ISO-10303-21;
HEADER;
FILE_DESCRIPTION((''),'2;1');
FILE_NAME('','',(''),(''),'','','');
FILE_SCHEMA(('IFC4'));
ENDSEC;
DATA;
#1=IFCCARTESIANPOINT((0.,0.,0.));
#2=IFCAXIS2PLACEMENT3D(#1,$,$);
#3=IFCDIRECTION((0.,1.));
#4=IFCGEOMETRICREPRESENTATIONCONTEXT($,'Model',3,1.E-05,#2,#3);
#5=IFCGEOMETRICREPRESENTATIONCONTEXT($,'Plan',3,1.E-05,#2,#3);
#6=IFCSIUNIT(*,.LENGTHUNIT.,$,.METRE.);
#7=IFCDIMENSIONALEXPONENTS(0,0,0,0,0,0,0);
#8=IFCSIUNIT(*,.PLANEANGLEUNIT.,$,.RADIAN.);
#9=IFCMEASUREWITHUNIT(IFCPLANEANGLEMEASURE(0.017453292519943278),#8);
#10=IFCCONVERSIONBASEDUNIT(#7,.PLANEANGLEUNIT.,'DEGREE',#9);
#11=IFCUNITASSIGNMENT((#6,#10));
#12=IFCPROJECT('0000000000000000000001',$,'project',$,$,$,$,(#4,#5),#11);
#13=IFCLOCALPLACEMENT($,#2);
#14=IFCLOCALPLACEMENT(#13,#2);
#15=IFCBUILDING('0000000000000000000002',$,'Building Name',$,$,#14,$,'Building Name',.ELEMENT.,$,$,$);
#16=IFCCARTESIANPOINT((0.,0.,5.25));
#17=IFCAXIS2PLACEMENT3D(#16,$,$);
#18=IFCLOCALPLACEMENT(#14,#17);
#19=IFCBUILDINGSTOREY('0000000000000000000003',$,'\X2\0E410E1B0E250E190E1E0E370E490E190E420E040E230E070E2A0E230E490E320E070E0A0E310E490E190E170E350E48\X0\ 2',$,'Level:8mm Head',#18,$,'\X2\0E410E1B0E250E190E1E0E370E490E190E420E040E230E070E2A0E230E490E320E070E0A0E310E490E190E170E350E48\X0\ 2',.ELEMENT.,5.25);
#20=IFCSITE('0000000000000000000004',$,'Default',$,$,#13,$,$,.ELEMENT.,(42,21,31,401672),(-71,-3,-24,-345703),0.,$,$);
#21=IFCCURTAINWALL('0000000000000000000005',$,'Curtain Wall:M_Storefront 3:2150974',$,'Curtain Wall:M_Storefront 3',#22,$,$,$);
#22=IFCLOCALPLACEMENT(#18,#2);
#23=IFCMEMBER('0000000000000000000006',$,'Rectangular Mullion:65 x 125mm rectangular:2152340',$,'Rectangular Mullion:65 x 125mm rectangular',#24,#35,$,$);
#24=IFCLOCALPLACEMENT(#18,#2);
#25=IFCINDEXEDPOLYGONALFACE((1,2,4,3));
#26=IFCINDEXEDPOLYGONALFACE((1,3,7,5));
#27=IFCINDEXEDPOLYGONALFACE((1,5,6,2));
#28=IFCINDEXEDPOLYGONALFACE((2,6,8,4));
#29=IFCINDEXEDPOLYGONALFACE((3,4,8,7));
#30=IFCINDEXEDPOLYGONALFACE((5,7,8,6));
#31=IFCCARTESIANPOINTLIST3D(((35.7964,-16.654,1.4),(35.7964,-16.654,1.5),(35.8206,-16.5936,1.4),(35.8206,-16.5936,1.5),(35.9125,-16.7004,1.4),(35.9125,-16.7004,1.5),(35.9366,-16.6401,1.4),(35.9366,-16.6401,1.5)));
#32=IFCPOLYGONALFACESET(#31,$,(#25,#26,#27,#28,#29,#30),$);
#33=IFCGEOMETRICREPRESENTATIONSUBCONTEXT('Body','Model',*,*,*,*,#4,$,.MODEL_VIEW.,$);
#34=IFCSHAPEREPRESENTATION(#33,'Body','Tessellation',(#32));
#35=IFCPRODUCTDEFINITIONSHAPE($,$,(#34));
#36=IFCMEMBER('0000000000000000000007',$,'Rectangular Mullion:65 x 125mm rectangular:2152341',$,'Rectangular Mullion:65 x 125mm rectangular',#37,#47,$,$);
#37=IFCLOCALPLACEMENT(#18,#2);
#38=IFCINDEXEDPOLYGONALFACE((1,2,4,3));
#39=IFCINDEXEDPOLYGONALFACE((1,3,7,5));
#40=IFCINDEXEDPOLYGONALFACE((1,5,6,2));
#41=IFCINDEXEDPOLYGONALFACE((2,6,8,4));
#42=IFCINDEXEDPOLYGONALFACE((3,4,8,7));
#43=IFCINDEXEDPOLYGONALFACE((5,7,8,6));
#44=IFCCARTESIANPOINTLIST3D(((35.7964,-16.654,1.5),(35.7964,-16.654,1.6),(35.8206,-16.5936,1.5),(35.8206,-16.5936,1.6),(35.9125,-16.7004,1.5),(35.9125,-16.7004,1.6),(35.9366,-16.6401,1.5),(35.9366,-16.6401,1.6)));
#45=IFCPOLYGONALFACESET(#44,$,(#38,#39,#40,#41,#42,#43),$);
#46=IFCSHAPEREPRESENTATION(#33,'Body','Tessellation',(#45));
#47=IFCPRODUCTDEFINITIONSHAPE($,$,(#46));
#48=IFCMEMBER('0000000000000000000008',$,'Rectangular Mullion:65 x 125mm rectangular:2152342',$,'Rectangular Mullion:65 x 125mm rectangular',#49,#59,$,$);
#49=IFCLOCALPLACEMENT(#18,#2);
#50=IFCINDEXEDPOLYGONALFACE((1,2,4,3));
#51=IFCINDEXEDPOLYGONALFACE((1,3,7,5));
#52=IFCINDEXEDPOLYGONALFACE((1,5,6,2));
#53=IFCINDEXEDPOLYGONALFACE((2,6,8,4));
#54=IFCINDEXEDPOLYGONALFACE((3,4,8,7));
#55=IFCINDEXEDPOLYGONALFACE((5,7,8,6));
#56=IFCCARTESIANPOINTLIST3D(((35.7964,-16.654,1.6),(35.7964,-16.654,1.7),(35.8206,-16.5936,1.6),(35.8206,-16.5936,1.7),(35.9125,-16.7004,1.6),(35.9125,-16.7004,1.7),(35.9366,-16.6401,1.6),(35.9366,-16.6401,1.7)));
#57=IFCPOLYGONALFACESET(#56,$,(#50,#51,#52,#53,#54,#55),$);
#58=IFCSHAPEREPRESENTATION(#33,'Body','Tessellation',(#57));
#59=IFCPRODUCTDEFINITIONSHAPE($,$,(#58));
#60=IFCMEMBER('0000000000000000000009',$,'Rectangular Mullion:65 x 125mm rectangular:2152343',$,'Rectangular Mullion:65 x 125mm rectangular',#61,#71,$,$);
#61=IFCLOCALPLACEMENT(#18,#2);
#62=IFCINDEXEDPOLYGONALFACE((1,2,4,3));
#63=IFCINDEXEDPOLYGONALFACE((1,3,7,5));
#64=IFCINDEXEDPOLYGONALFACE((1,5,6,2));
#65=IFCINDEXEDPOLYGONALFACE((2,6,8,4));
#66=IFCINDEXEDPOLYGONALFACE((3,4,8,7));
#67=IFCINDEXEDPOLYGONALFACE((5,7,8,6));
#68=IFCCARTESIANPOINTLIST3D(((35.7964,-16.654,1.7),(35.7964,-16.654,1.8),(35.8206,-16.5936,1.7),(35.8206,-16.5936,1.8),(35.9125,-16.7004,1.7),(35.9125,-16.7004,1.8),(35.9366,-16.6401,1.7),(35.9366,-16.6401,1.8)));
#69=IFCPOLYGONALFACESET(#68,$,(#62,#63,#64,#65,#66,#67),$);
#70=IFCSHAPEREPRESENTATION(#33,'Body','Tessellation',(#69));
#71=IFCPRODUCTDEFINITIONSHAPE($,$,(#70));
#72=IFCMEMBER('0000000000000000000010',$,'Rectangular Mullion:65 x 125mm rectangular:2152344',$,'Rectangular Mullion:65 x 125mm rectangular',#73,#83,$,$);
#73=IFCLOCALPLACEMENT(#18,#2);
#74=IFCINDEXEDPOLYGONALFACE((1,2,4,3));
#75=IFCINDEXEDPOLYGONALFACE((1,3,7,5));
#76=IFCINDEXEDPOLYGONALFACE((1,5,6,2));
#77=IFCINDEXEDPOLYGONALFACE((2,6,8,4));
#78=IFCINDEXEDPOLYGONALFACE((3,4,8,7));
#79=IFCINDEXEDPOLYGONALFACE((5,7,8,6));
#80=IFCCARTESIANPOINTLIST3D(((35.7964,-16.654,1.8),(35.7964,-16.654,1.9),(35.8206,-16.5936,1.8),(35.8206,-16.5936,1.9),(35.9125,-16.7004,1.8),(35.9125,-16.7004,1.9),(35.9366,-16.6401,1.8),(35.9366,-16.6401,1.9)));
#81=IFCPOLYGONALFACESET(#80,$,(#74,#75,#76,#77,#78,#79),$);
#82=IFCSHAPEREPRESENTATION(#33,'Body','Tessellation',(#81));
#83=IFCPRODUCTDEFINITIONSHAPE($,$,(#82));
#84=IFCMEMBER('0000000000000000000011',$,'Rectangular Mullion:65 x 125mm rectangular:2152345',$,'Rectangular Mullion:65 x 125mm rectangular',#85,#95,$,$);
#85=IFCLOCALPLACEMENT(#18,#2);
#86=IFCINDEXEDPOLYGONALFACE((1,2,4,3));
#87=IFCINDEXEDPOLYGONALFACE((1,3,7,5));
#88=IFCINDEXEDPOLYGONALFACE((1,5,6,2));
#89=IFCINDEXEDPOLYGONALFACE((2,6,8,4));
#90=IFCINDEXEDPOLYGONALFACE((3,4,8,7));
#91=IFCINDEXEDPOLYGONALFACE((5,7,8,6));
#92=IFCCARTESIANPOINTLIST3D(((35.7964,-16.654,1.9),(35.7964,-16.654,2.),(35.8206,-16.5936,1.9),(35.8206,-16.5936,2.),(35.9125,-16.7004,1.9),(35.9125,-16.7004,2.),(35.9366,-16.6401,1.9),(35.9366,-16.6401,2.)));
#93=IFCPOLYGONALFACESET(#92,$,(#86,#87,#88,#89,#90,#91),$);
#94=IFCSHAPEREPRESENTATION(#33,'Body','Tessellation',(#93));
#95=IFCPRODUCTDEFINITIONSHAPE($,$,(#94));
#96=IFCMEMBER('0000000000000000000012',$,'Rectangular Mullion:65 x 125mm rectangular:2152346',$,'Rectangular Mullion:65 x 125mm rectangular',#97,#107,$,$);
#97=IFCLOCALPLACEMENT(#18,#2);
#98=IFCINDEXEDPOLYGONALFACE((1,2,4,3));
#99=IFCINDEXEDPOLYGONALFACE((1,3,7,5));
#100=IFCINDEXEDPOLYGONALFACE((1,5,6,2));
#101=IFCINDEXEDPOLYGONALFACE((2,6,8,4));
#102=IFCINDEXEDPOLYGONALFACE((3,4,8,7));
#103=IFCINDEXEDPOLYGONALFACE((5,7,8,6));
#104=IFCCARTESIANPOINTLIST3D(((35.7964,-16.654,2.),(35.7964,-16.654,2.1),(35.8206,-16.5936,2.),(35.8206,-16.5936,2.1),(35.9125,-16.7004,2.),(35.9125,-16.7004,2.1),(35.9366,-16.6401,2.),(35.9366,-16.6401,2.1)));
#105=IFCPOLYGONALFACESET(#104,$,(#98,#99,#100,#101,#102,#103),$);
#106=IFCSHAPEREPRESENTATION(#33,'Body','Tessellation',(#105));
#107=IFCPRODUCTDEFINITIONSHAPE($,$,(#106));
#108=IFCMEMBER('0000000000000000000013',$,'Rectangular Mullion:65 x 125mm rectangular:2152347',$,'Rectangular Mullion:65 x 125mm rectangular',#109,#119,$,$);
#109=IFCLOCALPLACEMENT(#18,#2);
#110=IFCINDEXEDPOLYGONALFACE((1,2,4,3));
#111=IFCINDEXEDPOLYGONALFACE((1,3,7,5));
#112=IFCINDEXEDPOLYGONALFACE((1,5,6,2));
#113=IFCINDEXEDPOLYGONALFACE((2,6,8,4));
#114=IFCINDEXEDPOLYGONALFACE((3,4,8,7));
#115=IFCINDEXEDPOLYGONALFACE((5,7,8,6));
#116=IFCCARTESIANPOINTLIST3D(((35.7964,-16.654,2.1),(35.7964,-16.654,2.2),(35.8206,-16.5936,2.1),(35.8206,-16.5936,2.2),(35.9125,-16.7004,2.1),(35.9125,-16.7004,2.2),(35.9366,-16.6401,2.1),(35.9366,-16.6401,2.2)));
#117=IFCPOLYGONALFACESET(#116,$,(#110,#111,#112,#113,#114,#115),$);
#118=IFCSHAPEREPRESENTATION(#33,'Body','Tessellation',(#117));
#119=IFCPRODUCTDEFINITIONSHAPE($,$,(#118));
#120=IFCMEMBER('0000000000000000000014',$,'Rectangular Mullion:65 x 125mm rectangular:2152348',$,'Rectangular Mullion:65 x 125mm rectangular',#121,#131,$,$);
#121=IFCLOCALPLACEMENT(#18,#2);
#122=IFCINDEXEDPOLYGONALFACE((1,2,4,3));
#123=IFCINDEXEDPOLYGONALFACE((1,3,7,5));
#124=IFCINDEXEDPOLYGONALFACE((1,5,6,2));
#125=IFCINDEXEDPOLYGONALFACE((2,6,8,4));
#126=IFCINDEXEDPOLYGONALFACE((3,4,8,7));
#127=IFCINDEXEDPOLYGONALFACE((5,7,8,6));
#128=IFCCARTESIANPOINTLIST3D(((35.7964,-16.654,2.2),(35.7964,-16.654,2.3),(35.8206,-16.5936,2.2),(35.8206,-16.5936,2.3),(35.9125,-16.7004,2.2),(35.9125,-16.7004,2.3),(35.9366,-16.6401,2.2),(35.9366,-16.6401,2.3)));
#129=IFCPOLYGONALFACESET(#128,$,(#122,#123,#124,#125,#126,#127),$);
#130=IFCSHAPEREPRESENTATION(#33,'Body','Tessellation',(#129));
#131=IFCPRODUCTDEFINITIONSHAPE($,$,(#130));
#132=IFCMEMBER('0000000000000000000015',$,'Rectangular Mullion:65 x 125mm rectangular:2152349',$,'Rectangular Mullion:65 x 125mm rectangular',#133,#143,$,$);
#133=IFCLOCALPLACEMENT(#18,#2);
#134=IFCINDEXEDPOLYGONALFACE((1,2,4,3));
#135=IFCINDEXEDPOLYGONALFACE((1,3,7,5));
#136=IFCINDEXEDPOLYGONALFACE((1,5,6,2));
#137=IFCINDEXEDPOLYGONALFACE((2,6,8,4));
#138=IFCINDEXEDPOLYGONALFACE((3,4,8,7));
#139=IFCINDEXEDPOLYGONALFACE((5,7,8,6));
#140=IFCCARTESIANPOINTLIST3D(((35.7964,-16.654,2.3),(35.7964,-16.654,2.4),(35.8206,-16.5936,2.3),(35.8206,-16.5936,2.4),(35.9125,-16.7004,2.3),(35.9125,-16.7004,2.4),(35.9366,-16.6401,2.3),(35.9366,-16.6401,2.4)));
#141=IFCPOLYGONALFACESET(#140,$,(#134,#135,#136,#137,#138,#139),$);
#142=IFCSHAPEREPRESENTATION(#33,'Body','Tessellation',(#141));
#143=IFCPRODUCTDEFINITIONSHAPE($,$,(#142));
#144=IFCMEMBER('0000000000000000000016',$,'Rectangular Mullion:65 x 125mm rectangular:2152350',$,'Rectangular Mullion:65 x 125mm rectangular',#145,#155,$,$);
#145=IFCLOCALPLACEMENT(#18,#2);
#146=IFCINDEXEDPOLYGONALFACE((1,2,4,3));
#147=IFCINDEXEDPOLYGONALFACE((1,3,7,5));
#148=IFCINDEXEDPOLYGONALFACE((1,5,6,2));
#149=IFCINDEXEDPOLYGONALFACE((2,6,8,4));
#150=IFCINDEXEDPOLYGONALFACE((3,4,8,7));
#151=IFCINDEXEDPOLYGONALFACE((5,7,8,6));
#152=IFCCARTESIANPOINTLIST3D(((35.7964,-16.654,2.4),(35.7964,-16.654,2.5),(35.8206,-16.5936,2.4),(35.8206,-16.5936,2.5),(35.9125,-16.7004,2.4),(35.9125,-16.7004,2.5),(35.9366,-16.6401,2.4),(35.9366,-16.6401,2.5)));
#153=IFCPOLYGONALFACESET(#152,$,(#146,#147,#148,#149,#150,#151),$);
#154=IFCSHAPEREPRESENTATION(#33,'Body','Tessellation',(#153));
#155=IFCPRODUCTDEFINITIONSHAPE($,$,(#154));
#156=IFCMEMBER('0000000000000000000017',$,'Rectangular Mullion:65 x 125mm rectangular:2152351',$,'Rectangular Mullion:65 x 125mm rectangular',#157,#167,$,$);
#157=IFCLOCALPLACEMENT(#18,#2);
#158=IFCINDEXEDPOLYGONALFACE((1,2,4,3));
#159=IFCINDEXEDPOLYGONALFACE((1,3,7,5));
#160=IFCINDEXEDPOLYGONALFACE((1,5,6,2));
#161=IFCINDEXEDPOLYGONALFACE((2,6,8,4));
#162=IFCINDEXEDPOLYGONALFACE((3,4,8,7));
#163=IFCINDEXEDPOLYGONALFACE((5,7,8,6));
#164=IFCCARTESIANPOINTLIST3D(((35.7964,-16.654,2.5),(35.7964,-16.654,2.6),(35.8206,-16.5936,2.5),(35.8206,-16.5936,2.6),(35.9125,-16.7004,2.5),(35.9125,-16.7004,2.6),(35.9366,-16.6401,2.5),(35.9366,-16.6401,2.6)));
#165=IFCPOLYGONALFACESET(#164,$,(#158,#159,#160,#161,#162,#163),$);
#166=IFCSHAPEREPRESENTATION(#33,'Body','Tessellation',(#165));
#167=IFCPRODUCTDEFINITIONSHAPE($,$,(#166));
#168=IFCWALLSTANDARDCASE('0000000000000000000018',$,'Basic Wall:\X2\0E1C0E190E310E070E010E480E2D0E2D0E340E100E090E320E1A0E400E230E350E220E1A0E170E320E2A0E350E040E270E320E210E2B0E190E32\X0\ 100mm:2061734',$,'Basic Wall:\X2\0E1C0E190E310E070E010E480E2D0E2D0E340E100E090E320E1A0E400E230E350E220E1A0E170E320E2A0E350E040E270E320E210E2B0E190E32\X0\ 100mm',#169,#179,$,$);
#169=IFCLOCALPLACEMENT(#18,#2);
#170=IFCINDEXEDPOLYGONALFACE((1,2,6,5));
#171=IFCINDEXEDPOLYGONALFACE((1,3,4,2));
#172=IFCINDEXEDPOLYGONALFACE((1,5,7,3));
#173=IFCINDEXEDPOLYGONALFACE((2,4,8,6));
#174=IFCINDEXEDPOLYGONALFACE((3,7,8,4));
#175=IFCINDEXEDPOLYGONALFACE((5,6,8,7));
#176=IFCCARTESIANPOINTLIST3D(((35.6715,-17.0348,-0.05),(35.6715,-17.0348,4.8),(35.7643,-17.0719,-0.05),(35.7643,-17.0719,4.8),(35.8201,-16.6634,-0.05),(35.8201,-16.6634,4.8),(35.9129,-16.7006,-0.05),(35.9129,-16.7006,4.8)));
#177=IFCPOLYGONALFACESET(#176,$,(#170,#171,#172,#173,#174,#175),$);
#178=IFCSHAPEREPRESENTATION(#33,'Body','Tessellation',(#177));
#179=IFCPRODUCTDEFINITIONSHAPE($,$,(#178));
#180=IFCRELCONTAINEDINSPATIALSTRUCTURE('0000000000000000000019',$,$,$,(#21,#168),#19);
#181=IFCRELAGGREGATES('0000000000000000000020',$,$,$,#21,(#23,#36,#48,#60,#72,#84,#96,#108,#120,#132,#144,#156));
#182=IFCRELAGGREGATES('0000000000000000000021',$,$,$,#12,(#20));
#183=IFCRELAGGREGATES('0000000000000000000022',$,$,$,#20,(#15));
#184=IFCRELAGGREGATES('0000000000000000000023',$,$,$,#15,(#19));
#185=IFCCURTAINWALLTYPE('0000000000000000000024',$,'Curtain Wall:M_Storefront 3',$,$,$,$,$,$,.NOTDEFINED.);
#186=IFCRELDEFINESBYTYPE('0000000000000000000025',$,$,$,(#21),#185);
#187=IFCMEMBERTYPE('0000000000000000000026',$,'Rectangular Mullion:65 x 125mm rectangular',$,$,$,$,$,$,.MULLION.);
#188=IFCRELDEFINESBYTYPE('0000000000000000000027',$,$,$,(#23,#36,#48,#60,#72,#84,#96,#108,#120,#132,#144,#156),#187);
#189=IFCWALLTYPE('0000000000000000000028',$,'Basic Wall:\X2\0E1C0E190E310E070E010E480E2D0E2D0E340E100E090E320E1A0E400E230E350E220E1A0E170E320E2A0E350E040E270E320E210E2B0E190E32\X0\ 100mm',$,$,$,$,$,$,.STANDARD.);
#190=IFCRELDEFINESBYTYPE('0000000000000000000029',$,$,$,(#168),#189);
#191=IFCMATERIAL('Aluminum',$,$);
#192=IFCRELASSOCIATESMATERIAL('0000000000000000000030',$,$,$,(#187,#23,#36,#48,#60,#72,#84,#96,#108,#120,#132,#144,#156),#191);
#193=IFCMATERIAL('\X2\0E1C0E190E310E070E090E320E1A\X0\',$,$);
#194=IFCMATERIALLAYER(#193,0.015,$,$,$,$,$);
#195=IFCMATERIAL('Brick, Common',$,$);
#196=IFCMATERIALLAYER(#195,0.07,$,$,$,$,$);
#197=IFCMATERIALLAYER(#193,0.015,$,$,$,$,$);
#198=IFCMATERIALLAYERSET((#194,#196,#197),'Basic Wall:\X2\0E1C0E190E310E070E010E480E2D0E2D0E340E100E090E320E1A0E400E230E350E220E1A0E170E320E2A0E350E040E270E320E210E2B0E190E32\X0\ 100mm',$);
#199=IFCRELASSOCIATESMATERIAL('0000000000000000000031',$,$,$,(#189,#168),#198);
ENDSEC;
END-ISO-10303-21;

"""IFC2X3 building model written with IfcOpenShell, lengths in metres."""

from ifc_helpers import new_model, entity, si_unit, converted_unit, direction, frame, frame_2d, origin, origin_2d_with_axis, place, context, subcontext, project, spatial, rectangle, extrude, source, transform, mapped, material, layer, layer_set, layer_usage, type_object, type_shapes, element, aggregate, save


model = new_model("IFC2X3")

# Units and contexts
model_context = context("Model", 3, precision=1e-05, world=origin(), true_north=direction((0.0, 1.0)))
plan_context = context("Plan", 3, precision=1e-05, world=origin(), true_north=direction((0.0, 1.0)))
body_context = subcontext(model_context, "Body", "Model", "MODEL_VIEW")
ifc_project = project(units=[si_unit("LENGTHUNIT", "METRE"), converted_unit("PLANEANGLEUNIT", "DEGREE", entity("IfcPlaneAngleMeasure", 0.017453292519943278), si_unit("PLANEANGLEUNIT", "RADIAN"), dimensions=[0, 0, 0, 0, 0, 0, 0])], contexts=[model_context, plan_context])

# Site, building, storey
site_placement = place(None, origin())
site = spatial("IfcSite", under=ifc_project, at=site_placement, Name="Default", CompositionType="ELEMENT", RefLatitude=(42, 21, 31, 401672), RefLongitude=(-71, -3, -24, -345703), RefElevation=0.0)
building_placement = place(site_placement, origin())
building = spatial("IfcBuilding", under=site, at=building_placement, Name="Building Name", LongName="Building Name", CompositionType="ELEMENT")
storey_placement = place(building_placement, frame((0.0, 0.0, 5.25)))
storey = spatial("IfcBuildingStorey", under=building, at=storey_placement, Name="แปลนพื้นโครงสร้างชั้นที่ 2", ObjectType="Level:8mm Head", LongName="แปลนพื้นโครงสร้างชั้นที่ 2", CompositionType="ELEMENT", Elevation=5.25)

# Curtain wall, members
curtain_wall_type = type_object("IfcCurtainWallType", Name="Curtain Wall:M_Storefront 3", PredefinedType="NOTDEFINED")
ifc_material_1 = material(Name="Aluminum")
curtain_wall_1_placement = place(storey_placement, frame((0.0, 0.0, -5.25)))
curtain_wall_1 = element("IfcCurtainWall", 1, at=curtain_wall_1_placement, inside=storey, type_object=curtain_wall_type, Name="Curtain Wall:M_Storefront 3:2150974", ObjectType="Curtain Wall:M_Storefront 3")
member_type_1 = type_object("IfcMemberType", Name="Rectangular Mullion:65 x 125mm rectangular", PredefinedType="MULLION", material=ifc_material_1)
shared_shape_1 = source(origin(), body_context, "Body", "SweptSolid", [
    extrude(rectangle(XDim=0.065, YDim=0.125, at=origin_2d_with_axis()), frame((-0.0325, 0.0, -0.1), z_axis=(0.0, 0.0, 1.0), x_axis=(-1.0, 0.0, 0.0)), (0.0, 0.0, 1.0), 0.1),
])
type_shapes(member_type_1, [shared_shape_1])
member_1_placement = place(curtain_wall_1_placement, frame((35.8545, -16.6772, 6.75), z_axis=(0.0, 0.0, 1.0), x_axis=(-0.371573, -0.928404, 0.0)))
member_1 = element("IfcMember", 2, at=member_1_placement, type_object=member_type_1, material=ifc_material_1, Name="Rectangular Mullion:65 x 125mm rectangular:2152340", ObjectType="Rectangular Mullion:65 x 125mm rectangular", context=body_context, shape_type="MappedRepresentation", body=[
    mapped(shared_shape_1, transform((0.0, 0.0, 0.0), scale=1.0)),
])
member_2_placement = place(curtain_wall_1_placement, frame((35.8545, -16.6772, 6.85), z_axis=(0.0, 0.0, 1.0), x_axis=(-0.371573, -0.928404, 0.0)))
member_2 = element("IfcMember", 3, at=member_2_placement, type_object=member_type_1, material=ifc_material_1, Name="Rectangular Mullion:65 x 125mm rectangular:2152341", ObjectType="Rectangular Mullion:65 x 125mm rectangular", context=body_context, shape_type="MappedRepresentation", body=[
    mapped(shared_shape_1, transform((0.0, 0.0, 0.0), scale=1.0)),
])
member_3_placement = place(curtain_wall_1_placement, frame((35.8545, -16.6772, 6.95), z_axis=(0.0, 0.0, 1.0), x_axis=(-0.371573, -0.928404, 0.0)))
member_3 = element("IfcMember", 4, at=member_3_placement, type_object=member_type_1, material=ifc_material_1, Name="Rectangular Mullion:65 x 125mm rectangular:2152342", ObjectType="Rectangular Mullion:65 x 125mm rectangular", context=body_context, shape_type="MappedRepresentation", body=[
    mapped(shared_shape_1, transform((0.0, 0.0, 0.0), scale=1.0)),
])
member_4_placement = place(curtain_wall_1_placement, frame((35.8545, -16.6772, 7.05), z_axis=(0.0, 0.0, 1.0), x_axis=(-0.371573, -0.928404, 0.0)))
member_4 = element("IfcMember", 5, at=member_4_placement, type_object=member_type_1, material=ifc_material_1, Name="Rectangular Mullion:65 x 125mm rectangular:2152343", ObjectType="Rectangular Mullion:65 x 125mm rectangular", context=body_context, shape_type="MappedRepresentation", body=[
    mapped(shared_shape_1, transform((0.0, 0.0, 0.0), scale=1.0)),
])
member_5_placement = place(curtain_wall_1_placement, frame((35.8545, -16.6772, 7.15), z_axis=(0.0, 0.0, 1.0), x_axis=(-0.371573, -0.928404, 0.0)))
member_5 = element("IfcMember", 6, at=member_5_placement, type_object=member_type_1, material=ifc_material_1, Name="Rectangular Mullion:65 x 125mm rectangular:2152344", ObjectType="Rectangular Mullion:65 x 125mm rectangular", context=body_context, shape_type="MappedRepresentation", body=[
    mapped(shared_shape_1, transform((0.0, 0.0, 0.0), scale=1.0)),
])
member_6_placement = place(curtain_wall_1_placement, frame((35.8545, -16.6772, 7.25), z_axis=(0.0, 0.0, 1.0), x_axis=(-0.371573, -0.928404, 0.0)))
member_6 = element("IfcMember", 7, at=member_6_placement, type_object=member_type_1, material=ifc_material_1, Name="Rectangular Mullion:65 x 125mm rectangular:2152345", ObjectType="Rectangular Mullion:65 x 125mm rectangular", context=body_context, shape_type="MappedRepresentation", body=[
    mapped(shared_shape_1, transform((0.0, 0.0, 0.0), scale=1.0)),
])
member_7_placement = place(curtain_wall_1_placement, frame((35.8545, -16.6772, 7.35), z_axis=(0.0, 0.0, 1.0), x_axis=(-0.371573, -0.928404, 0.0)))
member_7 = element("IfcMember", 8, at=member_7_placement, type_object=member_type_1, material=ifc_material_1, Name="Rectangular Mullion:65 x 125mm rectangular:2152346", ObjectType="Rectangular Mullion:65 x 125mm rectangular", context=body_context, shape_type="MappedRepresentation", body=[
    mapped(shared_shape_1, transform((0.0, 0.0, 0.0), scale=1.0)),
])
member_8_placement = place(curtain_wall_1_placement, frame((35.8545, -16.6772, 7.45), z_axis=(0.0, 0.0, 1.0), x_axis=(-0.371573, -0.928404, 0.0)))
member_8 = element("IfcMember", 9, at=member_8_placement, type_object=member_type_1, material=ifc_material_1, Name="Rectangular Mullion:65 x 125mm rectangular:2152347", ObjectType="Rectangular Mullion:65 x 125mm rectangular", context=body_context, shape_type="MappedRepresentation", body=[
    mapped(shared_shape_1, transform((0.0, 0.0, 0.0), scale=1.0)),
])
member_9_placement = place(curtain_wall_1_placement, frame((35.8545, -16.6772, 7.55), z_axis=(0.0, 0.0, 1.0), x_axis=(-0.371573, -0.928404, 0.0)))
member_9 = element("IfcMember", 10, at=member_9_placement, type_object=member_type_1, material=ifc_material_1, Name="Rectangular Mullion:65 x 125mm rectangular:2152348", ObjectType="Rectangular Mullion:65 x 125mm rectangular", context=body_context, shape_type="MappedRepresentation", body=[
    mapped(shared_shape_1, transform((0.0, 0.0, 0.0), scale=1.0)),
])
member_10_placement = place(curtain_wall_1_placement, frame((35.8545, -16.6772, 7.65), z_axis=(0.0, 0.0, 1.0), x_axis=(-0.371573, -0.928404, 0.0)))
member_10 = element("IfcMember", 11, at=member_10_placement, type_object=member_type_1, material=ifc_material_1, Name="Rectangular Mullion:65 x 125mm rectangular:2152349", ObjectType="Rectangular Mullion:65 x 125mm rectangular", context=body_context, shape_type="MappedRepresentation", body=[
    mapped(shared_shape_1, transform((0.0, 0.0, 0.0), scale=1.0)),
])
member_11_placement = place(curtain_wall_1_placement, frame((35.8545, -16.6772, 7.75), z_axis=(0.0, 0.0, 1.0), x_axis=(-0.371573, -0.928404, 0.0)))
member_11 = element("IfcMember", 12, at=member_11_placement, type_object=member_type_1, material=ifc_material_1, Name="Rectangular Mullion:65 x 125mm rectangular:2152350", ObjectType="Rectangular Mullion:65 x 125mm rectangular", context=body_context, shape_type="MappedRepresentation", body=[
    mapped(shared_shape_1, transform((0.0, 0.0, 0.0), scale=1.0)),
])
member_12_placement = place(curtain_wall_1_placement, frame((35.8545, -16.6772, 7.85), z_axis=(0.0, 0.0, 1.0), x_axis=(-0.371573, -0.928404, 0.0)))
member_12 = element("IfcMember", 13, at=member_12_placement, type_object=member_type_1, material=ifc_material_1, Name="Rectangular Mullion:65 x 125mm rectangular:2152351", ObjectType="Rectangular Mullion:65 x 125mm rectangular", context=body_context, shape_type="MappedRepresentation", body=[
    mapped(shared_shape_1, transform((0.0, 0.0, 0.0), scale=1.0)),
])
aggregate(curtain_wall_1, [member_1, member_2, member_3, member_4, member_5, member_6, member_7, member_8, member_9, member_10, member_11, member_12])

# Wall
ifc_material_2 = material(Name="ผนังฉาบ")
ifc_layer_1 = layer(ifc_material_2, 0.015)
ifc_material_3 = material(Name="Brick, Common")
ifc_layer_2 = layer(ifc_material_3, 0.07)
ifc_layer_3 = layer(ifc_material_2, 0.015)
ifc_layer_set = layer_set([ifc_layer_1, ifc_layer_2, ifc_layer_3], Name="Basic Wall:ผนังก่ออิฐฉาบเรียบทาสีความหนา 100mm")
ifc_layer_usage = layer_usage(ifc_layer_set, "AXIS2", "POSITIVE", -0.05)
wall_type = type_object("IfcWallType", Name="Basic Wall:ผนังก่ออิฐฉาบเรียบทาสีความหนา 100mm", PredefinedType="STANDARD", material=ifc_layer_set)
wall_placement = place(storey_placement, frame((35.7179, -17.0534, -0.05), z_axis=(0.0, 0.0, 1.0), x_axis=(0.371573, 0.928404, 0.0)))
element("IfcWallStandardCase", 14, at=wall_placement, inside=storey, type_object=wall_type, material=ifc_layer_usage, Name="Basic Wall:ผนังก่ออิฐฉาบเรียบทาสีความหนา 100mm:2061734", ObjectType="Basic Wall:ผนังก่ออิฐฉาบเรียบทาสีความหนา 100mm", context=body_context, shape_type="SweptSolid", body=[
    extrude(rectangle(XDim=0.4, YDim=0.1, at=frame_2d((0.2, 0.0), x_axis=(-1.0, 0.0))), origin(), (0.0, 0.0, 1.0), 4.85),
])

save(model, "model.ifc")
